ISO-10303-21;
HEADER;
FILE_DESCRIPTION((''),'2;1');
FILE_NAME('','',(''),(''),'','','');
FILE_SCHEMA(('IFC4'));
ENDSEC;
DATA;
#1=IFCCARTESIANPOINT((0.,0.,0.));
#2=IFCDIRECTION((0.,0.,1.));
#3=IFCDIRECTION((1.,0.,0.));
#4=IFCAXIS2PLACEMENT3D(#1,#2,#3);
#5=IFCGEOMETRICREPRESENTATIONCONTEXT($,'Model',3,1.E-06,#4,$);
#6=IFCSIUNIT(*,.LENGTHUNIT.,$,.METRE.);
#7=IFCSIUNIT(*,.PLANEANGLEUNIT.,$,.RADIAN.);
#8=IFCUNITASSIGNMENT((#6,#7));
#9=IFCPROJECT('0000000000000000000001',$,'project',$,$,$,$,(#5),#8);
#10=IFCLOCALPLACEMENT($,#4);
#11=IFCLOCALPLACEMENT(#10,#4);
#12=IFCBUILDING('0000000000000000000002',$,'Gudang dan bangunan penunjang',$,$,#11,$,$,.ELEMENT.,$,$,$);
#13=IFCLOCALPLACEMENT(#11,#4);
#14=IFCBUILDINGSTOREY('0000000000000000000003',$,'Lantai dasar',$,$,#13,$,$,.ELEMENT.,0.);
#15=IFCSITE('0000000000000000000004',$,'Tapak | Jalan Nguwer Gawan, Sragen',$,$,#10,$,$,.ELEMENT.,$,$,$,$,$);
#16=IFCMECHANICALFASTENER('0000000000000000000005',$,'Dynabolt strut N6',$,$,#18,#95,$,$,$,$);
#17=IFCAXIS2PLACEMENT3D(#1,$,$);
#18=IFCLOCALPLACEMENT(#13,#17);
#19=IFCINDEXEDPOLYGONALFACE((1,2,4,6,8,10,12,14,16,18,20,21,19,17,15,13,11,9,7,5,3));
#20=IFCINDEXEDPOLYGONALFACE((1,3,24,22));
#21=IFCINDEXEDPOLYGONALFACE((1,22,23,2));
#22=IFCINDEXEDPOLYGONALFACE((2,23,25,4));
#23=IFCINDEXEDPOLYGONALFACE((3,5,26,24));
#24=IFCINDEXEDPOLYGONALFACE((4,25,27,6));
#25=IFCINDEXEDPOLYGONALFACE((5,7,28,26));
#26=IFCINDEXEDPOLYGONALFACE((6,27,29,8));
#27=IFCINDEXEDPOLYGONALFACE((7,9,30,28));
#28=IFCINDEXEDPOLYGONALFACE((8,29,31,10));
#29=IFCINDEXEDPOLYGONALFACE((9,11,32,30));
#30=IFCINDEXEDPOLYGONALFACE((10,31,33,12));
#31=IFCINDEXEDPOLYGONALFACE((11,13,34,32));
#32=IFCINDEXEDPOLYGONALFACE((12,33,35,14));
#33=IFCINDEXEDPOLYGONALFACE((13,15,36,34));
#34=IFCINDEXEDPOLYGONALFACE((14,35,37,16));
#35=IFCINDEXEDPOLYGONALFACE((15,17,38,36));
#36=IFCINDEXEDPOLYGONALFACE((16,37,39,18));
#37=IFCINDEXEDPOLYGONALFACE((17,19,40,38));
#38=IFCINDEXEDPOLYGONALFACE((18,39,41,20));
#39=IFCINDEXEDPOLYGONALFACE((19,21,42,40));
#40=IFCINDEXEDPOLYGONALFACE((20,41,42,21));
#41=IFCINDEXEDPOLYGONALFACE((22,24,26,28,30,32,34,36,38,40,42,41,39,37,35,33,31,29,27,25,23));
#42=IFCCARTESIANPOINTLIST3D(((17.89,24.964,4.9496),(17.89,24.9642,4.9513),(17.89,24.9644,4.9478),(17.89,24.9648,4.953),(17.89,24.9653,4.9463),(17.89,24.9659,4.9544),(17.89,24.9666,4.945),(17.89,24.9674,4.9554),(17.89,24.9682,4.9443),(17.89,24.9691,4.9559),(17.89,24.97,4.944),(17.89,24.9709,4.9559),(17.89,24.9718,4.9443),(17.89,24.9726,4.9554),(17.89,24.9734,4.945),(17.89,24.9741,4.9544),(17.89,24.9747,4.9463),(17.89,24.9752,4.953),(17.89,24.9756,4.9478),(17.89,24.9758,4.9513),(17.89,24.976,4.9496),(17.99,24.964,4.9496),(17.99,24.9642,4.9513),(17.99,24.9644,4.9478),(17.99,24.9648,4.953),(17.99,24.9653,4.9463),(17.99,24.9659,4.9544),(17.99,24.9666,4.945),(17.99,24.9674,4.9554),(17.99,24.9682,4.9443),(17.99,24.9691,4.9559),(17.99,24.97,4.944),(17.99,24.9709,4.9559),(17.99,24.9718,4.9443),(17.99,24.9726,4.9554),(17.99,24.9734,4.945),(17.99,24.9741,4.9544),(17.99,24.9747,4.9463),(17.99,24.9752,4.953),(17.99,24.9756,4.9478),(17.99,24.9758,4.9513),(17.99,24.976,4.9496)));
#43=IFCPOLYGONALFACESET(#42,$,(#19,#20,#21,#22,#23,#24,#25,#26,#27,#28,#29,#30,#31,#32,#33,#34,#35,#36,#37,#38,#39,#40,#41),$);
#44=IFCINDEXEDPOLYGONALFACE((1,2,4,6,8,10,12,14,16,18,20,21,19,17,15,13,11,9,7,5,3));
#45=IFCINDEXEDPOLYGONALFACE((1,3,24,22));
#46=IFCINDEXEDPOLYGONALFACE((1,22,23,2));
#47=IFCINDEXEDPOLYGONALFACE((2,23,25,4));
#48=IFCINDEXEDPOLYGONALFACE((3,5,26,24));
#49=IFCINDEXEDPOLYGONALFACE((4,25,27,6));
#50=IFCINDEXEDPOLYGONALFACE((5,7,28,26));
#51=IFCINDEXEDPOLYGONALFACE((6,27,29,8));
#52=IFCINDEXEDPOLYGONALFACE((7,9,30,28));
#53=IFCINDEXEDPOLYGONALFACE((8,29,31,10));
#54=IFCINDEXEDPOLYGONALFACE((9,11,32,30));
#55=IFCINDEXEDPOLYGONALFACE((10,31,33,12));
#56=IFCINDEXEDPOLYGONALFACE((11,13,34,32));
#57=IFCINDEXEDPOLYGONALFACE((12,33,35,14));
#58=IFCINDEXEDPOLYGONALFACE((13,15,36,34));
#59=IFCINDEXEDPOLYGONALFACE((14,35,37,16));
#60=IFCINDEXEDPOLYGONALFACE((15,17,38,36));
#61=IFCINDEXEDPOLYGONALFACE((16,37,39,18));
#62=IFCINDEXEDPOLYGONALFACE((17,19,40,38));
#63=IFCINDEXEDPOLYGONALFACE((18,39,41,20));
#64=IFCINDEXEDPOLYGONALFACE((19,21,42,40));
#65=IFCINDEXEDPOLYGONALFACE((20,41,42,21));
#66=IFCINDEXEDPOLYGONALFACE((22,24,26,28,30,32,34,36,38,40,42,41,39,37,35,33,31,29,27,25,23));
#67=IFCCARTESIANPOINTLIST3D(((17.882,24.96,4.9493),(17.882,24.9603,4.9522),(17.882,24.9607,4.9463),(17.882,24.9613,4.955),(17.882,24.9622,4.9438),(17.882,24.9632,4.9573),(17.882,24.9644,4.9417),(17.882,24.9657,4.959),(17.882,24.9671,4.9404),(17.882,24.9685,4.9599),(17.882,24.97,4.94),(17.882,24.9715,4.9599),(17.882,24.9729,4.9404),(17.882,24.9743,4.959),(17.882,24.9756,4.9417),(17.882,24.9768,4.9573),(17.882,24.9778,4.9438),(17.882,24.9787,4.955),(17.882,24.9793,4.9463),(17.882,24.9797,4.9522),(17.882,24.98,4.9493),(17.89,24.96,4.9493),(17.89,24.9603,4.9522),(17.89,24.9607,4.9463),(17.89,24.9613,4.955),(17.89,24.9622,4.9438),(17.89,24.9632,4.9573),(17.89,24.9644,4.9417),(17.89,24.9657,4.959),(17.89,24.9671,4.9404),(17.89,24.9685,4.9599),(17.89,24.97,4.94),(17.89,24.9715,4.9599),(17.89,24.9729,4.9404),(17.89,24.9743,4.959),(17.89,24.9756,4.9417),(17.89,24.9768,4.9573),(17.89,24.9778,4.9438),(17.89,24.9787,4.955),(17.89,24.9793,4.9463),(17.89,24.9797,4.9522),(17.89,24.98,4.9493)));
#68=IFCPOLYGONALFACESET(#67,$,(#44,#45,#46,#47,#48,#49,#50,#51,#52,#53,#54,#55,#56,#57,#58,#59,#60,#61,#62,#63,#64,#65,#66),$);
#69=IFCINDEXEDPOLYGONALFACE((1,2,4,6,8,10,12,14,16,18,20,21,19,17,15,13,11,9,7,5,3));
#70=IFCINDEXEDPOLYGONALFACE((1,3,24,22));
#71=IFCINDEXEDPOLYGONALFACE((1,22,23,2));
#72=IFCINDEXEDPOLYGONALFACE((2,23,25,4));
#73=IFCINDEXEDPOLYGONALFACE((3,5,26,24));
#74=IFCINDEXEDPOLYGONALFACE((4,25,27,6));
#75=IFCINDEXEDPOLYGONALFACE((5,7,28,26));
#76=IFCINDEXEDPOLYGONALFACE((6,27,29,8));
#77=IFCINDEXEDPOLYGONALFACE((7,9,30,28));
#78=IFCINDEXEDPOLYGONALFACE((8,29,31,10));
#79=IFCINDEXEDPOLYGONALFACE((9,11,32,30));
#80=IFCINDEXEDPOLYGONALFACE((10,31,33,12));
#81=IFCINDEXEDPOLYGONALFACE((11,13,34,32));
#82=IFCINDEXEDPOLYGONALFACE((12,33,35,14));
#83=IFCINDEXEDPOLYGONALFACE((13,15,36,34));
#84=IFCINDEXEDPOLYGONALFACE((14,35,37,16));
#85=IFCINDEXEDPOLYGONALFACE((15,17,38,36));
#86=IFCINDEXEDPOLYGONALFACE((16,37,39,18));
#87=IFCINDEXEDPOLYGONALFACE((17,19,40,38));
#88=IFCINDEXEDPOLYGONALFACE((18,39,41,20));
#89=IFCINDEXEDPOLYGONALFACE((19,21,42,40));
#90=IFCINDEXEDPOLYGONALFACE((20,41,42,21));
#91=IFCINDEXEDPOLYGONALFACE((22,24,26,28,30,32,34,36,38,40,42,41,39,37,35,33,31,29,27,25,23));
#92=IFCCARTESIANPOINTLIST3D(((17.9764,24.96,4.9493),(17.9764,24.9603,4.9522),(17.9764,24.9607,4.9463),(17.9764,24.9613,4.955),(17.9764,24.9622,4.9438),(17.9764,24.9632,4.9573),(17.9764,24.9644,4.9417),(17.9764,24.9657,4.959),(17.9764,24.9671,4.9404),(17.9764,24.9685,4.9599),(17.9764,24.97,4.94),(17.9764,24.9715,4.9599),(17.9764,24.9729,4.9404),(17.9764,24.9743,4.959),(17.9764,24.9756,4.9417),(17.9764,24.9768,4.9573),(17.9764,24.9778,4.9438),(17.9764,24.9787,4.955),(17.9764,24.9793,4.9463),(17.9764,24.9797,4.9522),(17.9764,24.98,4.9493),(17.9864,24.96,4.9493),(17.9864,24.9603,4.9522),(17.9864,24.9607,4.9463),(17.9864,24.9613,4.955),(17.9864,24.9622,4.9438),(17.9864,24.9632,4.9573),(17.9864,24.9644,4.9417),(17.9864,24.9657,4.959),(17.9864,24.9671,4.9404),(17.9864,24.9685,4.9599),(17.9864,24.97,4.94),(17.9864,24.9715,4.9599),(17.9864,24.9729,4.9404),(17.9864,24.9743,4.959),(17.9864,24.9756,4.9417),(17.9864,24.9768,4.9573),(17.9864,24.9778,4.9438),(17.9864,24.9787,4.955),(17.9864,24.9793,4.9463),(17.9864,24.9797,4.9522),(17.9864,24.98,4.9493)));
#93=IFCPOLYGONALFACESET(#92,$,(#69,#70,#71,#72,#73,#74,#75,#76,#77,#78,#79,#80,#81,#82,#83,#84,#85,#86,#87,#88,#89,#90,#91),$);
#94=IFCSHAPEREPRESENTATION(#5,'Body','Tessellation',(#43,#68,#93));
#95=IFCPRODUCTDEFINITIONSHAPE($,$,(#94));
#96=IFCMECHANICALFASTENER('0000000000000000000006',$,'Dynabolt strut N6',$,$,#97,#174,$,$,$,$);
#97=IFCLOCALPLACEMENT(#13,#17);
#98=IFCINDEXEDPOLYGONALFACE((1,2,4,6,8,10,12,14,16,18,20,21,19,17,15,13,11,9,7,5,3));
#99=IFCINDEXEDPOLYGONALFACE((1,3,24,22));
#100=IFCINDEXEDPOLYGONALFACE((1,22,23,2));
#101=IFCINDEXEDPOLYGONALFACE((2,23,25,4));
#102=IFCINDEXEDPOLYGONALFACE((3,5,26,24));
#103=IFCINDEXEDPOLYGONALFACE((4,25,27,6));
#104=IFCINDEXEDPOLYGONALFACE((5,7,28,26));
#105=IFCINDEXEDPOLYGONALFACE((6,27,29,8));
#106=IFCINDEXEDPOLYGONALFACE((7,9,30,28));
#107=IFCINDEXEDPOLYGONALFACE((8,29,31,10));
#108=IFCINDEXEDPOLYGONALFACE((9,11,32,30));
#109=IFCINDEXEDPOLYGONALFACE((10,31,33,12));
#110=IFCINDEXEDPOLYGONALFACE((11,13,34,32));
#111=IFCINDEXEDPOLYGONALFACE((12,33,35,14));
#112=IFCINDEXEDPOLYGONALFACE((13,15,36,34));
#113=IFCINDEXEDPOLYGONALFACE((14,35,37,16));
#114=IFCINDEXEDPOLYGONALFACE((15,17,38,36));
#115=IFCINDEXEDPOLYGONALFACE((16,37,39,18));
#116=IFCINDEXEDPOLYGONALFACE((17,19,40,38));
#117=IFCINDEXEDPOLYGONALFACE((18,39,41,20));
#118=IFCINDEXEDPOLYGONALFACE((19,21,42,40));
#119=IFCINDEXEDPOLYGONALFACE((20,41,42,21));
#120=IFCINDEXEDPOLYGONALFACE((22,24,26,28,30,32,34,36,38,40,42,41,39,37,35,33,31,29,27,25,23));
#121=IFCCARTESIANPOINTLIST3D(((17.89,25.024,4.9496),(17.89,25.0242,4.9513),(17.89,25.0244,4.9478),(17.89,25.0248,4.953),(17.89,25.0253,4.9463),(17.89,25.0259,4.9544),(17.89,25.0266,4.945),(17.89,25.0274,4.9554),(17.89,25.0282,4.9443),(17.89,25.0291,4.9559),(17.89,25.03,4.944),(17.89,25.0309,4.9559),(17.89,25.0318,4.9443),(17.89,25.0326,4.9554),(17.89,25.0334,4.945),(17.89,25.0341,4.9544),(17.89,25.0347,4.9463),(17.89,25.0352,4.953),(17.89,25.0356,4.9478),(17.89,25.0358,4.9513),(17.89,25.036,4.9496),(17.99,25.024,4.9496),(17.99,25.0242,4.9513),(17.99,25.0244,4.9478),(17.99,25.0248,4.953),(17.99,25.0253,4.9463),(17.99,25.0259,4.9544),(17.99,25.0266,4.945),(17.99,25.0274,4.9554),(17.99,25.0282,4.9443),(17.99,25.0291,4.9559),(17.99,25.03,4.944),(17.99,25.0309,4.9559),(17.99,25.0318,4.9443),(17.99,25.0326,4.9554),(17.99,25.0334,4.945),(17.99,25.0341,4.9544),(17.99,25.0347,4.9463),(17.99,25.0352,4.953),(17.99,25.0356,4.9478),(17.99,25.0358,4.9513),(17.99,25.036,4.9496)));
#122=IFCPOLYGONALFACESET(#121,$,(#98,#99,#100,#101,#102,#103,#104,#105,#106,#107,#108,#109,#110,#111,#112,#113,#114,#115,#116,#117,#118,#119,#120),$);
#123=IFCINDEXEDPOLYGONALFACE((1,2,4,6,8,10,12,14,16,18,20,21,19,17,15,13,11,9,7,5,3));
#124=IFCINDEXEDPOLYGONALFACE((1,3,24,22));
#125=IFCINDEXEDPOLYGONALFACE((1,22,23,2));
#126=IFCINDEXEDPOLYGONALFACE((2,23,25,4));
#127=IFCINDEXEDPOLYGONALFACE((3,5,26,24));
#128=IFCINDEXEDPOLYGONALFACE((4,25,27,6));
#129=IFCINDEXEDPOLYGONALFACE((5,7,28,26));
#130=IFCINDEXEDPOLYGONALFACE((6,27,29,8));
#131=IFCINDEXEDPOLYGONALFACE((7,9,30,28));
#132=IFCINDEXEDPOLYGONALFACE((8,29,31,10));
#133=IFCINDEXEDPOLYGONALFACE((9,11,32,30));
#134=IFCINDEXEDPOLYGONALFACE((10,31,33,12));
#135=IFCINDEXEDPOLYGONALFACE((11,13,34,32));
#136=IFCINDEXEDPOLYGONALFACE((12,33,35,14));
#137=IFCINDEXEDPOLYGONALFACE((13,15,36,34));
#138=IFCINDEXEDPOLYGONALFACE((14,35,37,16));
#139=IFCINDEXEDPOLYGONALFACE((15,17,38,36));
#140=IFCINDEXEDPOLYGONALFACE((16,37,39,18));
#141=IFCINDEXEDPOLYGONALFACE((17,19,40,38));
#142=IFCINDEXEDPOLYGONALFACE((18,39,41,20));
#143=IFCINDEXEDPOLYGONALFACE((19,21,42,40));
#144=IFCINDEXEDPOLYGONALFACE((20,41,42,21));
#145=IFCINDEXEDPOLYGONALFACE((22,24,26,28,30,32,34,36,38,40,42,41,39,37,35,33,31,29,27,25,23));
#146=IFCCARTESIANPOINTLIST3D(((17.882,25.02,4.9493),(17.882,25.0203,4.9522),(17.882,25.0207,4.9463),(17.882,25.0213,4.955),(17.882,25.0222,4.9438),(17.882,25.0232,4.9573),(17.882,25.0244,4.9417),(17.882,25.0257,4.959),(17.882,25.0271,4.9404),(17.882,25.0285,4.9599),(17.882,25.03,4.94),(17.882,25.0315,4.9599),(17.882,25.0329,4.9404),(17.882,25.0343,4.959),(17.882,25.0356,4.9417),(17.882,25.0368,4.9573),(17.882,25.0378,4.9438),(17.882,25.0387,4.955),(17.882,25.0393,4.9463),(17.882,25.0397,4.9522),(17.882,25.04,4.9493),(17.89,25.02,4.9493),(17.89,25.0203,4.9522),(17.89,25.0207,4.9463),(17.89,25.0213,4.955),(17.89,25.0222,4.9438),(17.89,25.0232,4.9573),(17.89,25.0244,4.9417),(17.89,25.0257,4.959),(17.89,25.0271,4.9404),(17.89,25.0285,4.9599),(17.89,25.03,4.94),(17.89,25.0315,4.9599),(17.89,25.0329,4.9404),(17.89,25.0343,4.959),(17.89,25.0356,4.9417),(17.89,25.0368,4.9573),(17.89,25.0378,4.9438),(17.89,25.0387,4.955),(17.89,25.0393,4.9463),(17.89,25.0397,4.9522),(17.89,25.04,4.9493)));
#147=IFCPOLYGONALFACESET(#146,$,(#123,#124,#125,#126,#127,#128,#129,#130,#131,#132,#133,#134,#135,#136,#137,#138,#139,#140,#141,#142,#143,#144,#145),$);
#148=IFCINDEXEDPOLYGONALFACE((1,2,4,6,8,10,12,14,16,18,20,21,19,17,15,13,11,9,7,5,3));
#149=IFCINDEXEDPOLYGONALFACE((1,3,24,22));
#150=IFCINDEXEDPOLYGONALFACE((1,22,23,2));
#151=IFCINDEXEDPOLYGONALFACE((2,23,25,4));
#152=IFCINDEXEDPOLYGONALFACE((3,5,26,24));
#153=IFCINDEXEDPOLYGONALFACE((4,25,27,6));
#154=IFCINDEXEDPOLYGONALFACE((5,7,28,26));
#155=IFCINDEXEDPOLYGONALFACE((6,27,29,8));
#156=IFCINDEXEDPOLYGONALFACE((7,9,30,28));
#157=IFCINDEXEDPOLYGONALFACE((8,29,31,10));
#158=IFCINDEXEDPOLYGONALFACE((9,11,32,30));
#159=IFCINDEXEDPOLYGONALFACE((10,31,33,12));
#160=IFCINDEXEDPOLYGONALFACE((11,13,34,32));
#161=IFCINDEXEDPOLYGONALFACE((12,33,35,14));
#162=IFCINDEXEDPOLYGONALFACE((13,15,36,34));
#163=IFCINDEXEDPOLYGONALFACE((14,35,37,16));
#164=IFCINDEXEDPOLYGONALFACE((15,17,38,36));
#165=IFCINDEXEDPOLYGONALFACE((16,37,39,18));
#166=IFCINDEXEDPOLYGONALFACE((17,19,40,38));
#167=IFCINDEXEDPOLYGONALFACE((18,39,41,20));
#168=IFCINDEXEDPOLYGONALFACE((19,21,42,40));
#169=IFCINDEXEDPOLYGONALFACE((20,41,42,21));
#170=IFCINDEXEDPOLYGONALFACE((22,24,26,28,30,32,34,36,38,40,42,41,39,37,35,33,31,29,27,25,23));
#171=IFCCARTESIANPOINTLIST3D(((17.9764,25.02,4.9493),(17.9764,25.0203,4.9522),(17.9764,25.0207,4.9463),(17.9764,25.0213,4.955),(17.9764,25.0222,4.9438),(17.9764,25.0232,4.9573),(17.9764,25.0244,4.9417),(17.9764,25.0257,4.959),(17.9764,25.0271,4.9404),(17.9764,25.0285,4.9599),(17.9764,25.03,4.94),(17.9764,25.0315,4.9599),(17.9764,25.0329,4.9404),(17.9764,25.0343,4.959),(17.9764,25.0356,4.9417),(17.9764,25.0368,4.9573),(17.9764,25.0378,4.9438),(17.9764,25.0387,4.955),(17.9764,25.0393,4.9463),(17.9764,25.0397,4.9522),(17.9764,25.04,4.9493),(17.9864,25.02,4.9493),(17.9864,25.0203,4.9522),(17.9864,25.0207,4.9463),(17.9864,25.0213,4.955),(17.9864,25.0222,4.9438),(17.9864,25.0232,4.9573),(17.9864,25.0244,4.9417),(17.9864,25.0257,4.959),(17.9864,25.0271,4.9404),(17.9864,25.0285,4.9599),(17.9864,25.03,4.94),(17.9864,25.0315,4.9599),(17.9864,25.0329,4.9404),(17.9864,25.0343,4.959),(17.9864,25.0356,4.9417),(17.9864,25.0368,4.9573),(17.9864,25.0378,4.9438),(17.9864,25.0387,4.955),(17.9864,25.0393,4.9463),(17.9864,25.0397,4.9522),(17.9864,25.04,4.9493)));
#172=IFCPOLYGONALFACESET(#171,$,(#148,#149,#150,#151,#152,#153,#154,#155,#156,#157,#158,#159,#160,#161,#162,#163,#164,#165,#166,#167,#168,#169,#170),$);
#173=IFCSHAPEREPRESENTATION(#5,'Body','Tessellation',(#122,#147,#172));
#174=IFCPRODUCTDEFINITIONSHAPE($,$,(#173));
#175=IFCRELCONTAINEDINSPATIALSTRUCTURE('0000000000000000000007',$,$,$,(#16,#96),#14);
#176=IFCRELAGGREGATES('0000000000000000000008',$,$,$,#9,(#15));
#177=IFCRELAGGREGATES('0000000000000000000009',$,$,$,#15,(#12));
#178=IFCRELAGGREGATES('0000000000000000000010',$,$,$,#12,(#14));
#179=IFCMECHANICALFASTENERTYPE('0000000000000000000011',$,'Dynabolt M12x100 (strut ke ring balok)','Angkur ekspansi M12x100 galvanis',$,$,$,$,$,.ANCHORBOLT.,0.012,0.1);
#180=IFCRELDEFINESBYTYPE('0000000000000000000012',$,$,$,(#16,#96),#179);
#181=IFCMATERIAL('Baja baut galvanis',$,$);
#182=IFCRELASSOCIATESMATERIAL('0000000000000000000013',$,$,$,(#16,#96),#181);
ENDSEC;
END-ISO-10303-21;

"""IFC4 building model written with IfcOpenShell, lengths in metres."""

from ifc_helpers import new_model, si_unit, frame, origin_with_axes, place, context, project, spatial, circle, extrude, source, transform, mapped, material, type_object, type_shapes, element, save


model = new_model("IFC4")

# Units and contexts
model_context = context("Model", 3, precision=1e-06, world=origin_with_axes())
ifc_project = project(units=[si_unit("LENGTHUNIT", "METRE"), si_unit("PLANEANGLEUNIT", "RADIAN")], contexts=[model_context])

# Site, building, storey
site_placement = place(None, origin_with_axes())
site = spatial("IfcSite", under=ifc_project, at=site_placement, Name="Tapak | Jalan Nguwer Gawan, Sragen", CompositionType="ELEMENT")
building_placement = place(site_placement, origin_with_axes())
building = spatial("IfcBuilding", under=site, at=building_placement, Name="Gudang dan bangunan penunjang", CompositionType="ELEMENT")
storey_placement = place(building_placement, origin_with_axes())
storey = spatial("IfcBuildingStorey", under=building, at=storey_placement, Name="Lantai dasar", CompositionType="ELEMENT", Elevation=0.0)

# Mechanical fasteners
ifc_material = material(Name="Baja baut galvanis")
mechanical_fastener_type = type_object("IfcMechanicalFastenerType", Name="Dynabolt M12x100 (strut ke ring balok)", Description="Angkur ekspansi M12x100 galvanis", NominalDiameter=0.012, NominalLength=0.1, PredefinedType="ANCHORBOLT")
shared_shape = source(origin_with_axes(), model_context, "Body", "SweptSolid", [
    extrude(circle(Radius=0.006), origin_with_axes(), (0.0, 0.0, 1.0), 0.1),
    extrude(circle(Radius=0.01), frame((0.0, 0.0, -0.008), z_axis=(0.0, 0.0, 1.0), x_axis=(1.0, 0.0, 0.0)), (0.0, 0.0, 1.0), 0.008),
    extrude(circle(Radius=0.01), frame((0.0, 0.0, 0.0864), z_axis=(0.0, 0.0, 1.0), x_axis=(1.0, 0.0, 0.0)), (0.0, 0.0, 1.0), 0.01),
])
type_shapes(mechanical_fastener_type, [shared_shape])
placement = place(None, origin_with_axes())
element("IfcMechanicalFastener", 1, at=placement, inside=storey, type_object=mechanical_fastener_type, material=ifc_material, Name="Dynabolt strut N6", context=model_context, shape_type="MappedRepresentation", body=[
    mapped(shared_shape, transform((17.89, 24.97, 4.95), x_axis=(0.0, 0.0, -1.0), y_axis=(0.0, 1.0, 0.0), z_axis=(1.0, 0.0, 0.0), scale=1.0)),
])
element("IfcMechanicalFastener", 2, at=placement, inside=storey, type_object=mechanical_fastener_type, material=ifc_material, Name="Dynabolt strut N6", context=model_context, shape_type="MappedRepresentation", body=[
    mapped(shared_shape, transform((17.89, 25.03, 4.95), x_axis=(0.0, 0.0, -1.0), y_axis=(0.0, 1.0, 0.0), z_axis=(1.0, 0.0, 0.0), scale=1.0)),
])

save(model, "model.ifc")
